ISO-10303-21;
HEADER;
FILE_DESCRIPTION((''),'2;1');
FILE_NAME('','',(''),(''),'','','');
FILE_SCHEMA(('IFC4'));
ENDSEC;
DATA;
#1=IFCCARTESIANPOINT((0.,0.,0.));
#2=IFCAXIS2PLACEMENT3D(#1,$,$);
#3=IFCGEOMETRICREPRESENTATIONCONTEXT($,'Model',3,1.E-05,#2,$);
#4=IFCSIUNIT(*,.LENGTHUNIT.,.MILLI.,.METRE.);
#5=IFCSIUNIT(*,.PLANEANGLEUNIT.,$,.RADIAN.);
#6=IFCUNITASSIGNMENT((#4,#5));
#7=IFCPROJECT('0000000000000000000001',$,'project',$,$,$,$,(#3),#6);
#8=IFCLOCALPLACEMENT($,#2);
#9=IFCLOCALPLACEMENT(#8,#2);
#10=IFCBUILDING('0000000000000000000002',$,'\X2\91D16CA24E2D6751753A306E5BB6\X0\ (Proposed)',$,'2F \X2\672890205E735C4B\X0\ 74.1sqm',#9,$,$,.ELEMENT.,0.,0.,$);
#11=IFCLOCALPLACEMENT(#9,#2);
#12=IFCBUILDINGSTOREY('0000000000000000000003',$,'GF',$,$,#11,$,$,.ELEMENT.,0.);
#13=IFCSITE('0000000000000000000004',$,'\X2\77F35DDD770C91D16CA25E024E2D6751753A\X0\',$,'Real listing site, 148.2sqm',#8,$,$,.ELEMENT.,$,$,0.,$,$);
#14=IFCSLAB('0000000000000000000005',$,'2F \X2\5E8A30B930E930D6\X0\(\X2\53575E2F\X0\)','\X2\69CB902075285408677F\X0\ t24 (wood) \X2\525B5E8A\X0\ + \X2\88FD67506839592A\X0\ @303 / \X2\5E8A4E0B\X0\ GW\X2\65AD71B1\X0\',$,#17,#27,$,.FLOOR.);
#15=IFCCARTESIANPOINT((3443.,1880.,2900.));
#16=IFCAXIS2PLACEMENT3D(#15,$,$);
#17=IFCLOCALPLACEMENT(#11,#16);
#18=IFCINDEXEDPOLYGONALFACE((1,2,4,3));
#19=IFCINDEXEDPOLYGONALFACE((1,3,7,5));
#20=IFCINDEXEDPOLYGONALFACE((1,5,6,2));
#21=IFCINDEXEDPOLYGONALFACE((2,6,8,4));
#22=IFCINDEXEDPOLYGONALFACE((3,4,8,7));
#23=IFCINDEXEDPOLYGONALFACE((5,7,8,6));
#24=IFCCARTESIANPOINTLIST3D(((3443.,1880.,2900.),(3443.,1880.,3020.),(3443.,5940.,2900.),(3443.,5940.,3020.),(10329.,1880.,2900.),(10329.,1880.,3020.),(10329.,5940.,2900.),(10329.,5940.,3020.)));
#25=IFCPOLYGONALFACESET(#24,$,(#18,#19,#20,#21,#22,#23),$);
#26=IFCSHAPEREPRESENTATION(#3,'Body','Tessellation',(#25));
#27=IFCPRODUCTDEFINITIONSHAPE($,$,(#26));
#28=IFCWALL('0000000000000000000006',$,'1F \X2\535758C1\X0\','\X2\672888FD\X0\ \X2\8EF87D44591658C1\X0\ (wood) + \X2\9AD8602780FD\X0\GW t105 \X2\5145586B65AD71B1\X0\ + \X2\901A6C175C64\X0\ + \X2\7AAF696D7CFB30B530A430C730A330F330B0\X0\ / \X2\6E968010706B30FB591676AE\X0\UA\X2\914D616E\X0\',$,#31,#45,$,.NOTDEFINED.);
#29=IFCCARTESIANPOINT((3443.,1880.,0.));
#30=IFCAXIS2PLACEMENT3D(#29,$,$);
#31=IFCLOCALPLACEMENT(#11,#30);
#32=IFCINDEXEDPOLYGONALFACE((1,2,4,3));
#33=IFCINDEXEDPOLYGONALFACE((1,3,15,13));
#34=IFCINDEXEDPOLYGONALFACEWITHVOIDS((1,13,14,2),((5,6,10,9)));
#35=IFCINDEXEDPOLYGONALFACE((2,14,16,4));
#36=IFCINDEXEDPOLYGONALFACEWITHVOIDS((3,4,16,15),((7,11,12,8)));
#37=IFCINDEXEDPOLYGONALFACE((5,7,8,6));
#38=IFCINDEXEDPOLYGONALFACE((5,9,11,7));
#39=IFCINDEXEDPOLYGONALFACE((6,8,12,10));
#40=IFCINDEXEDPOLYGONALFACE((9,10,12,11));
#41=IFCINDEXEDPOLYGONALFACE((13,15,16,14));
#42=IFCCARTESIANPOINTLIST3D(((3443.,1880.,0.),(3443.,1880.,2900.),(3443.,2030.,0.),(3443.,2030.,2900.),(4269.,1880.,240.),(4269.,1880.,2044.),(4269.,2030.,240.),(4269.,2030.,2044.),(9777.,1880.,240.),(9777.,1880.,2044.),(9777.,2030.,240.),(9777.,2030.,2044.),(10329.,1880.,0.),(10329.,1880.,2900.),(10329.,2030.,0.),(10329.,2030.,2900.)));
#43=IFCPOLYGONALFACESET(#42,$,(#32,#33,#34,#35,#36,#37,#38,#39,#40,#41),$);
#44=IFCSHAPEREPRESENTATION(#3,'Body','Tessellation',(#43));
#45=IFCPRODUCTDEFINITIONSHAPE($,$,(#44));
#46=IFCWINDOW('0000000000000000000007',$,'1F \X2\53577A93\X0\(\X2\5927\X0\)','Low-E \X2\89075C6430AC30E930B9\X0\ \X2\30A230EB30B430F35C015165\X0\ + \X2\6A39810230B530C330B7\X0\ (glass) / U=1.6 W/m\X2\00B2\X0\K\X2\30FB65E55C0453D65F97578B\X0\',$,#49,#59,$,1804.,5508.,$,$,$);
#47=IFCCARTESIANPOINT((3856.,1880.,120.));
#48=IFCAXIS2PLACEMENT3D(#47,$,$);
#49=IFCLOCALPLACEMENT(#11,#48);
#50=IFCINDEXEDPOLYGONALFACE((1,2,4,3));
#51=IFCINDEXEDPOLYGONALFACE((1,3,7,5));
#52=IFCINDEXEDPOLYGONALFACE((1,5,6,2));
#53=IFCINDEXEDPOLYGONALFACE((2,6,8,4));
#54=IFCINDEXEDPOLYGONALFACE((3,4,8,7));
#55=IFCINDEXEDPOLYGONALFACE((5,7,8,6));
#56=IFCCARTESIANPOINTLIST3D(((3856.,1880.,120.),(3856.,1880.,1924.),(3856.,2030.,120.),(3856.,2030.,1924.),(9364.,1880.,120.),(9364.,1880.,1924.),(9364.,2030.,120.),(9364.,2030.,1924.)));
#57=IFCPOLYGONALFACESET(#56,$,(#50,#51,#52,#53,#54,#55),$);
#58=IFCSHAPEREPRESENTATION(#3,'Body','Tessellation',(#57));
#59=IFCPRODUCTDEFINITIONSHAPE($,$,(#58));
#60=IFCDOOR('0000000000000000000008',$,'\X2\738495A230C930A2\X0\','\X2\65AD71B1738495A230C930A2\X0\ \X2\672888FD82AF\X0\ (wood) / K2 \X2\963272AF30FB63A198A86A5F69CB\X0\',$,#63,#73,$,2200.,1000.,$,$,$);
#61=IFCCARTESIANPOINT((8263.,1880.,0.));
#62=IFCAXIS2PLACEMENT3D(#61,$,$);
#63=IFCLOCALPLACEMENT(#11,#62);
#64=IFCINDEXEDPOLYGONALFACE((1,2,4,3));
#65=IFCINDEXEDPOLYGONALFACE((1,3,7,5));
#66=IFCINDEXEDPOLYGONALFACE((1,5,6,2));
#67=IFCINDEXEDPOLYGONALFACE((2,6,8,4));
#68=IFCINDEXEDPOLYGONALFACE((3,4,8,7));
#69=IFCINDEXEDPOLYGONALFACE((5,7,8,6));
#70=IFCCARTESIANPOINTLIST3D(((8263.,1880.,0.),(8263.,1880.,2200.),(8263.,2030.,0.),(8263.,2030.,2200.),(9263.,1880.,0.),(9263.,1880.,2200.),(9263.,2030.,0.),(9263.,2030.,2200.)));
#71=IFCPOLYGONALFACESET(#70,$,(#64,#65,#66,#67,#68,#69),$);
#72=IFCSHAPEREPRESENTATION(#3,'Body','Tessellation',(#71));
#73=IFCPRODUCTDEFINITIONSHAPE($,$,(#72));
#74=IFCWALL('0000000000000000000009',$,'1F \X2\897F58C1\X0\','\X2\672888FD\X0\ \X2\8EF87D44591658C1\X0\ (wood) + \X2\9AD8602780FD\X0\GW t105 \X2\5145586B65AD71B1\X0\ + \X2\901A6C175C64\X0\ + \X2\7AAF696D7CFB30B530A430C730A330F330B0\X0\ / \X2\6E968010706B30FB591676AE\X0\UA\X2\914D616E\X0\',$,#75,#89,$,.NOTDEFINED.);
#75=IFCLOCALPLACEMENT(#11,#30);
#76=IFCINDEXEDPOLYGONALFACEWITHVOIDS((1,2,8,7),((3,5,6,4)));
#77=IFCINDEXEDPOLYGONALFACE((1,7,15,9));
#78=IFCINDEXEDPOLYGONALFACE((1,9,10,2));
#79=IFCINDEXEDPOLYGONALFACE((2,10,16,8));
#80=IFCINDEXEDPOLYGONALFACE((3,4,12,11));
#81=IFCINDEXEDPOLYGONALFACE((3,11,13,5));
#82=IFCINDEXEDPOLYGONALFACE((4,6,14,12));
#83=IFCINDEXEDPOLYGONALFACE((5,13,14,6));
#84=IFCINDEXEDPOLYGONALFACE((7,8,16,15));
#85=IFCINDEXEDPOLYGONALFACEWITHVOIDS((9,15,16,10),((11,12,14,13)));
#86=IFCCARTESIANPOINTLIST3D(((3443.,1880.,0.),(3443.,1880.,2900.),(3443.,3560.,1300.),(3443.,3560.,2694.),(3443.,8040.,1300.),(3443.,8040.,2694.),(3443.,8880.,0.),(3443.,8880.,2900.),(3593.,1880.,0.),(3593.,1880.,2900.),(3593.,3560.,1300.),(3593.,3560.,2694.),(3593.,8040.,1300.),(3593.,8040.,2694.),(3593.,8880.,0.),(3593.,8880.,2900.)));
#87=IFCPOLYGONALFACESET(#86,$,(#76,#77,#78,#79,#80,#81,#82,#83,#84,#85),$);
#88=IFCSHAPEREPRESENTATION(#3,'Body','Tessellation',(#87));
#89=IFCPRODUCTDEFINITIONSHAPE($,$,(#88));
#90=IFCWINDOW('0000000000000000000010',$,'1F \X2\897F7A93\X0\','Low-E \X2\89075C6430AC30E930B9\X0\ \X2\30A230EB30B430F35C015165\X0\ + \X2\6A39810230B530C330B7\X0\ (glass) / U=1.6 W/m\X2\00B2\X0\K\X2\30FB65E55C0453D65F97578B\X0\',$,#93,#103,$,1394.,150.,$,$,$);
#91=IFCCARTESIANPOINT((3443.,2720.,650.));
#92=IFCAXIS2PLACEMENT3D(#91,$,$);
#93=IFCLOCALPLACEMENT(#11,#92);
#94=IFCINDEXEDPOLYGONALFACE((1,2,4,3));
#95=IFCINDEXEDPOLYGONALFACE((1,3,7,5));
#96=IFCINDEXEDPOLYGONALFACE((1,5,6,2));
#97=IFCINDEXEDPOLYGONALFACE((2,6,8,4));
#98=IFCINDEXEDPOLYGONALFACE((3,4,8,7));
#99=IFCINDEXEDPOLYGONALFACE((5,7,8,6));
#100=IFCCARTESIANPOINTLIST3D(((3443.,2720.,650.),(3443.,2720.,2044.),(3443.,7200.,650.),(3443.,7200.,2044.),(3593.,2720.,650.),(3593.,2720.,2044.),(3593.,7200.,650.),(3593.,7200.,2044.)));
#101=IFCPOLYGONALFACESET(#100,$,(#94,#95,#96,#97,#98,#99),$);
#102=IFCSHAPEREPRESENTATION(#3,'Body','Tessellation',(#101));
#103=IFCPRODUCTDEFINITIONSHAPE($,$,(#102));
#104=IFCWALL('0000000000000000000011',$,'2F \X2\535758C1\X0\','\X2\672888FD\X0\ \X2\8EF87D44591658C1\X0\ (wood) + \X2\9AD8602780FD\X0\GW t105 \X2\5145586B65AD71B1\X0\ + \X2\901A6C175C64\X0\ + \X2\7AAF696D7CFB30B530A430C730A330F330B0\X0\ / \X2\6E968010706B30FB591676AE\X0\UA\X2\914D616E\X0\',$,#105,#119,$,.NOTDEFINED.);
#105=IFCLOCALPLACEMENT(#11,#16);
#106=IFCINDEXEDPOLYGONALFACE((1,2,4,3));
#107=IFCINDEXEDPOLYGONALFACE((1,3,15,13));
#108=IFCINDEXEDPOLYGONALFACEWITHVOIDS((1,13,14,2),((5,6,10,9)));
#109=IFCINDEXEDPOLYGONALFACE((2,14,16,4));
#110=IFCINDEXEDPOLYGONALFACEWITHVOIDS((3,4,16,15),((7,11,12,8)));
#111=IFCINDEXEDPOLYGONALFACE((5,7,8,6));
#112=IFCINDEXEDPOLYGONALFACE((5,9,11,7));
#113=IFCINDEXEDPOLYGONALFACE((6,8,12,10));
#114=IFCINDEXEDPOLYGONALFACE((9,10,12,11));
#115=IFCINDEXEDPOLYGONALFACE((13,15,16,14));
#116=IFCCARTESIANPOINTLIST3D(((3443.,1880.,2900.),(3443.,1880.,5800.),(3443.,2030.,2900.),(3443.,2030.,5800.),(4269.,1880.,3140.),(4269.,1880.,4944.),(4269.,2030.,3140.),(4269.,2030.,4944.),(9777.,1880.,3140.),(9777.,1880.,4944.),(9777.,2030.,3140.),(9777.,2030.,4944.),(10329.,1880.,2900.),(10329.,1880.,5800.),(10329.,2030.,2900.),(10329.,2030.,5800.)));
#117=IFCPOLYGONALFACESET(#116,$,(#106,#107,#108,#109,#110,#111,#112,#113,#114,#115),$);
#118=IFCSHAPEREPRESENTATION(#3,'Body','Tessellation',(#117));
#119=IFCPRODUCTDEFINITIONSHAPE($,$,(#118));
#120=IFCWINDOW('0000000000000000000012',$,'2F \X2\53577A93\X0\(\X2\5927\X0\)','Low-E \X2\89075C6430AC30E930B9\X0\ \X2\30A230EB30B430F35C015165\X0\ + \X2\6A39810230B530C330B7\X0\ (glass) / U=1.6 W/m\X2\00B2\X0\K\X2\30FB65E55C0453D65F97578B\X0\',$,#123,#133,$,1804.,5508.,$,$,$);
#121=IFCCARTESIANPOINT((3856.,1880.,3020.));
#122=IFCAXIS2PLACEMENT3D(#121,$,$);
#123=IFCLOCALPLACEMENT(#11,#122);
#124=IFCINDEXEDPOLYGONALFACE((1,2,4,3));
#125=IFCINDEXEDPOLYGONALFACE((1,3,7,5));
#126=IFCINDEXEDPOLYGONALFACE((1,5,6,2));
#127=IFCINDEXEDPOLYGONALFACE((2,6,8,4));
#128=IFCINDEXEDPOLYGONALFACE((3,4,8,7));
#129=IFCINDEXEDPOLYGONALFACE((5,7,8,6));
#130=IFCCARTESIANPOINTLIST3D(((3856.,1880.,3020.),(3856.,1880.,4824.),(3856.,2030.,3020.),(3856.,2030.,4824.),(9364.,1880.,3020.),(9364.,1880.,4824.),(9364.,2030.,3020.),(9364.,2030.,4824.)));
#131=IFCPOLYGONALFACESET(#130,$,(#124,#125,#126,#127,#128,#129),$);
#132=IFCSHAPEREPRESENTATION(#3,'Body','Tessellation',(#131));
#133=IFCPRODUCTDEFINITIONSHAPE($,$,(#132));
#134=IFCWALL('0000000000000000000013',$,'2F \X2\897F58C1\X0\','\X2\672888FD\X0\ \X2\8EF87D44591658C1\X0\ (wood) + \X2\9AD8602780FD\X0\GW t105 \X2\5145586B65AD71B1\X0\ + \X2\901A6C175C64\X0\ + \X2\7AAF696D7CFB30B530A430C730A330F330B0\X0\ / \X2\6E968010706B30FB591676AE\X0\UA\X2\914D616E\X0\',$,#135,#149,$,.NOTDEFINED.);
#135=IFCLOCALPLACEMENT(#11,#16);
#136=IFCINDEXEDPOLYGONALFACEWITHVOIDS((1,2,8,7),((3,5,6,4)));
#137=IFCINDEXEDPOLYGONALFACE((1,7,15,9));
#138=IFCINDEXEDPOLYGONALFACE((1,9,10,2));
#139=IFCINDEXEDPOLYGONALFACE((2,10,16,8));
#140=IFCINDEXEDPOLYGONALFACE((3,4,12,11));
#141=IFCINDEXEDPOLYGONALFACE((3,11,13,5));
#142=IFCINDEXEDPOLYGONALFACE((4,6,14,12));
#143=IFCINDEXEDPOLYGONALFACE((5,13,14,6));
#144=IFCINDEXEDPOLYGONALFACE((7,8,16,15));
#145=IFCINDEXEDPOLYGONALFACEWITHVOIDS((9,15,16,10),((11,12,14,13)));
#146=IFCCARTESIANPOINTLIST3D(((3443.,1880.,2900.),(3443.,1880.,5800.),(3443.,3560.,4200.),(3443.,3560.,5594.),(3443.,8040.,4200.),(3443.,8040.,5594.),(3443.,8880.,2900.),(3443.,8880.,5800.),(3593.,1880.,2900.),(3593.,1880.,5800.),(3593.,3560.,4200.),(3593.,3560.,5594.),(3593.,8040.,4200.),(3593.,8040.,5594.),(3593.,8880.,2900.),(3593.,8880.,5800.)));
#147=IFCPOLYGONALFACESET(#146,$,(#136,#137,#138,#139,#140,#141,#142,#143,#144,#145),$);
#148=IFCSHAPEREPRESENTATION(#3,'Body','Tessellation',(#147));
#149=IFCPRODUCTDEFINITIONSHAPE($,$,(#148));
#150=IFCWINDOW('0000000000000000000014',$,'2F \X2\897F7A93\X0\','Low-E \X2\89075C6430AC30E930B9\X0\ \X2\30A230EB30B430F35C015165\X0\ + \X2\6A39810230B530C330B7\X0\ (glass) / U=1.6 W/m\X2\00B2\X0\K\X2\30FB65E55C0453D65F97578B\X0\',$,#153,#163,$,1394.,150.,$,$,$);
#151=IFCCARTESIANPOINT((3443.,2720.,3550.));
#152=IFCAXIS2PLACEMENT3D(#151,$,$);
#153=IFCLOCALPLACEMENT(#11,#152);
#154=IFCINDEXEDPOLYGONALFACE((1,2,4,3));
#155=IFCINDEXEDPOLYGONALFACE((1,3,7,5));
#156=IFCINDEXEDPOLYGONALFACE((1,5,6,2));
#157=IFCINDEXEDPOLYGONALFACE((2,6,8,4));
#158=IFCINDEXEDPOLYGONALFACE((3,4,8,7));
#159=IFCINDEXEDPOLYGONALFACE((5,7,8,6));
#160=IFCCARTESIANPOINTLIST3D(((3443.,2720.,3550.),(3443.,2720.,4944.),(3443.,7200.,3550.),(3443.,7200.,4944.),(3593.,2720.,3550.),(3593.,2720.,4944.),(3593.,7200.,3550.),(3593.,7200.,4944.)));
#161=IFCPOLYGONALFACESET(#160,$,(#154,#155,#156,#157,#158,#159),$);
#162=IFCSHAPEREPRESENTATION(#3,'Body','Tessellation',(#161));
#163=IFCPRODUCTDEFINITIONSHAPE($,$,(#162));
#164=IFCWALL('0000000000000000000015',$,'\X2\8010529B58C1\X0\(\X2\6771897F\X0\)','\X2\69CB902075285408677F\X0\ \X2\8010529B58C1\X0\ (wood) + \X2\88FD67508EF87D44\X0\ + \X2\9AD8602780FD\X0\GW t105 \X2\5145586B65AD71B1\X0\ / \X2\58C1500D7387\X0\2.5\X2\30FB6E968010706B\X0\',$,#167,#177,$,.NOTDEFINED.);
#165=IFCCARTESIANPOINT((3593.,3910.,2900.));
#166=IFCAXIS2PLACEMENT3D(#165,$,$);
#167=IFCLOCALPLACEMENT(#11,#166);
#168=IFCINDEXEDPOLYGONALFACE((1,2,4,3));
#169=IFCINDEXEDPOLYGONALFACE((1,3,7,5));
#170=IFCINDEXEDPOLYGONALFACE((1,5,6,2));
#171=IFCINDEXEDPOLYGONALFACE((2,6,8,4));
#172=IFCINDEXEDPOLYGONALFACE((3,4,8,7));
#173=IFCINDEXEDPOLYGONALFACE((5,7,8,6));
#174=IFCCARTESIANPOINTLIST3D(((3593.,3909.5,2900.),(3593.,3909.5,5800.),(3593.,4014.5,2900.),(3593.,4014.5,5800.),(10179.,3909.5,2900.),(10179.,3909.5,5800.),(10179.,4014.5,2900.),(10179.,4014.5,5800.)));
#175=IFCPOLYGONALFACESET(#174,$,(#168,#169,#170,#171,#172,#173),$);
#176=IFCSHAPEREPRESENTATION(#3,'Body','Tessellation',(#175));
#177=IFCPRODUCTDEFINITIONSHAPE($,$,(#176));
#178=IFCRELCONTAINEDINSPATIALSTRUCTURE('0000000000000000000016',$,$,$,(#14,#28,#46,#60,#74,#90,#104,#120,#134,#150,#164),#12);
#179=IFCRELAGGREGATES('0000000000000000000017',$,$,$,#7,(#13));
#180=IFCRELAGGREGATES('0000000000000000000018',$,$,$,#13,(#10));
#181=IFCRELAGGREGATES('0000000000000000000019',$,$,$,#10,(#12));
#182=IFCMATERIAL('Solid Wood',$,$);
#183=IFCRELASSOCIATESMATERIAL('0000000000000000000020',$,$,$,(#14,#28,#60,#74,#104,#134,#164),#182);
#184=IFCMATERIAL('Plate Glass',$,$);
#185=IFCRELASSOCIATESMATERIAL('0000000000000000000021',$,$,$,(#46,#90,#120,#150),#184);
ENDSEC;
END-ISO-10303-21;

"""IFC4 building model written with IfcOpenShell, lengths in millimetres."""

from ifc_helpers import new_model, si_unit, frame, frame_2d, origin, place, context, project, spatial, rectangle, extrude, material, element, fill, save


model = new_model("IFC4")

# Units and contexts
model_context = context("Model", 3, precision=1e-05, world=origin())
ifc_project = project(units=[si_unit("LENGTHUNIT", "METRE", prefix="MILLI"), si_unit("PLANEANGLEUNIT", "RADIAN")], contexts=[model_context])

# Site, building, storey
site_placement = place(None, origin())
site = spatial("IfcSite", under=ifc_project, at=site_placement, Name="石川県金沢市中村町", ObjectType="Real listing site, 148.2sqm", CompositionType="ELEMENT", RefElevation=0.0)
building_placement = place(site_placement, origin())
building = spatial("IfcBuilding", under=site, at=building_placement, Name="金沢中村町の家 (Proposed)", ObjectType="2F 木造平屋 74.1sqm", CompositionType="ELEMENT", ElevationOfRefHeight=0.0, ElevationOfTerrain=0.0)
storey_placement = place(building_placement, origin())
storey = spatial("IfcBuildingStorey", under=building, at=storey_placement, Name="GF", CompositionType="ELEMENT", Elevation=0.0)

# Slab
ifc_material_1 = material(Name="Solid Wood")
slab_1_placement = place(storey_placement, frame((3443.0, 1880.0, 2900.0)))
element("IfcSlab", 1, at=slab_1_placement, inside=storey, material=ifc_material_1, Name="2F 床スラブ(南帯)", Description="構造用合板 t24 (wood) 剛床 + 製材根太 @303 / 床下 GW断熱", PredefinedType="FLOOR", context=model_context, shape_type="SweptSolid", body=[
    extrude(rectangle(XDim=6886.0, YDim=4060.0, at=frame_2d((3443.0, 2030.0))), frame((3443.0, 1880.0, 2900.0)), (0.0, 0.0, 1.0), 120.0),
])

# Wall, openings, window, door
wall_1_placement = place(storey_placement, frame((3443.0, 1880.0, 0.0)))
wall_1 = element("IfcWall", 2, at=wall_1_placement, inside=storey, material=ifc_material_1, Name="1F 南壁", Description="木製 軸組外壁 (wood) + 高性能GW t105 充填断熱 + 通気層 + 窯業系サイディング / 準耐火・外皮UA配慮", PredefinedType="NOTDEFINED", context=model_context, shape_type="SweptSolid", body=[
    extrude(rectangle(XDim=6886.0, YDim=150.0, at=frame_2d((3443.0, 75.0))), frame((3443.0, 1880.0, 0.0)), (0.0, 0.0, 1.0), 2900.0),
])
opening_1_placement = place(storey_placement, frame((3856.0, 1880.0, 120.0)))
opening_1 = element("IfcOpeningElement", 3, at=opening_1_placement, cuts=wall_1, PredefinedType="NOTDEFINED", context=model_context, shape_type="SweptSolid", body=[
    extrude(rectangle(XDim=5508.0, YDim=150.0, at=frame_2d((2754.0, 75.0))), frame((3856.0, 1880.0, 120.0)), (0.0, 0.0, 1.0), 1804.0),
])
opening_2_placement = place(storey_placement, frame((8263.0, 1880.0, 0.0)))
opening_2 = element("IfcOpeningElement", 4, at=opening_2_placement, cuts=wall_1, PredefinedType="NOTDEFINED", context=model_context, shape_type="SweptSolid", body=[
    extrude(rectangle(XDim=1000.0, YDim=150.0, at=frame_2d((500.0, 75.0))), frame((8263.0, 1880.0, 0.0)), (0.0, 0.0, 1.0), 2200.0),
])
ifc_material_2 = material(Name="Plate Glass")
window_1_placement = place(storey_placement, frame((3856.0, 1880.0, 120.0)))
window_1 = element("IfcWindow", 5, at=window_1_placement, inside=storey, material=ifc_material_2, Name="1F 南窓(大)", Description="Low-E 複層ガラス アルゴン封入 + 樹脂サッシ (glass) / U=1.6 W/m²K・日射取得型", OverallHeight=1804.0, OverallWidth=5508.0, context=model_context, shape_type="SweptSolid", body=[
    extrude(rectangle(XDim=5508.0, YDim=150.0, at=frame_2d((2754.0, 75.0))), frame((3856.0, 1880.0, 120.0)), (0.0, 0.0, 1.0), 1804.0),
])
fill(opening_1, window_1)
door_placement = place(storey_placement, frame((8263.0, 1880.0, 0.0)))
door = element("IfcDoor", 6, at=door_placement, inside=storey, material=ifc_material_1, Name="玄関ドア", Description="断熱玄関ドア 木製芯 (wood) / K2 防犯・採風機構", OverallHeight=2200.0, OverallWidth=1000.0, context=model_context, shape_type="SweptSolid", body=[
    extrude(rectangle(XDim=1000.0, YDim=150.0, at=frame_2d((500.0, 75.0))), frame((8263.0, 1880.0, 0.0)), (0.0, 0.0, 1.0), 2200.0),
])
fill(opening_2, door)

# Wall, opening, window
wall_2_placement = place(storey_placement, frame((3443.0, 1880.0, 0.0)))
wall_2 = element("IfcWall", 7, at=wall_2_placement, inside=storey, material=ifc_material_1, Name="1F 西壁", Description="木製 軸組外壁 (wood) + 高性能GW t105 充填断熱 + 通気層 + 窯業系サイディング / 準耐火・外皮UA配慮", PredefinedType="NOTDEFINED", context=model_context, shape_type="SweptSolid", body=[
    extrude(rectangle(XDim=150.0, YDim=7000.0, at=frame_2d((75.0, 3500.0))), frame((3443.0, 1880.0, 0.0)), (0.0, 0.0, 1.0), 2900.0),
])
opening_3_placement = place(storey_placement, frame((3443.0, 2720.0, 650.0)))
opening_3 = element("IfcOpeningElement", 8, at=opening_3_placement, cuts=wall_2, PredefinedType="NOTDEFINED", context=model_context, shape_type="SweptSolid", body=[
    extrude(rectangle(XDim=150.0, YDim=4480.0, at=frame_2d((75.0, 2240.0))), frame((3443.0, 2720.0, 650.0)), (0.0, 0.0, 1.0), 1394.0),
])
window_2_placement = place(storey_placement, frame((3443.0, 2720.0, 650.0)))
window_2 = element("IfcWindow", 9, at=window_2_placement, inside=storey, material=ifc_material_2, Name="1F 西窓", Description="Low-E 複層ガラス アルゴン封入 + 樹脂サッシ (glass) / U=1.6 W/m²K・日射取得型", OverallHeight=1394.0, OverallWidth=150.0, context=model_context, shape_type="SweptSolid", body=[
    extrude(rectangle(XDim=150.0, YDim=4480.0, at=frame_2d((75.0, 2240.0))), frame((3443.0, 2720.0, 650.0)), (0.0, 0.0, 1.0), 1394.0),
])
fill(opening_3, window_2)

# Walls, openings, windows
wall_3_placement = place(storey_placement, frame((3443.0, 1880.0, 2900.0)))
wall_3 = element("IfcWall", 10, at=wall_3_placement, inside=storey, material=ifc_material_1, Name="2F 南壁", Description="木製 軸組外壁 (wood) + 高性能GW t105 充填断熱 + 通気層 + 窯業系サイディング / 準耐火・外皮UA配慮", PredefinedType="NOTDEFINED", context=model_context, shape_type="SweptSolid", body=[
    extrude(rectangle(XDim=6886.0, YDim=150.0, at=frame_2d((3443.0, 75.0))), frame((3443.0, 1880.0, 2900.0)), (0.0, 0.0, 1.0), 2900.0),
])
opening_4_placement = place(storey_placement, frame((3856.0, 1880.0, 3020.0)))
opening_4 = element("IfcOpeningElement", 11, at=opening_4_placement, cuts=wall_3, PredefinedType="NOTDEFINED", context=model_context, shape_type="SweptSolid", body=[
    extrude(rectangle(XDim=5508.0, YDim=150.0, at=frame_2d((2754.0, 75.0))), frame((3856.0, 1880.0, 3020.0)), (0.0, 0.0, 1.0), 1804.0),
])
window_3_placement = place(storey_placement, frame((3856.0, 1880.0, 3020.0)))
window_3 = element("IfcWindow", 12, at=window_3_placement, inside=storey, material=ifc_material_2, Name="2F 南窓(大)", Description="Low-E 複層ガラス アルゴン封入 + 樹脂サッシ (glass) / U=1.6 W/m²K・日射取得型", OverallHeight=1804.0, OverallWidth=5508.0, context=model_context, shape_type="SweptSolid", body=[
    extrude(rectangle(XDim=5508.0, YDim=150.0, at=frame_2d((2754.0, 75.0))), frame((3856.0, 1880.0, 3020.0)), (0.0, 0.0, 1.0), 1804.0),
])
fill(opening_4, window_3)
wall_4_placement = place(storey_placement, frame((3443.0, 1880.0, 2900.0)))
wall_4 = element("IfcWall", 13, at=wall_4_placement, inside=storey, material=ifc_material_1, Name="2F 西壁", Description="木製 軸組外壁 (wood) + 高性能GW t105 充填断熱 + 通気層 + 窯業系サイディング / 準耐火・外皮UA配慮", PredefinedType="NOTDEFINED", context=model_context, shape_type="SweptSolid", body=[
    extrude(rectangle(XDim=150.0, YDim=7000.0, at=frame_2d((75.0, 3500.0))), frame((3443.0, 1880.0, 2900.0)), (0.0, 0.0, 1.0), 2900.0),
])
opening_5_placement = place(storey_placement, frame((3443.0, 2720.0, 3550.0)))
opening_5 = element("IfcOpeningElement", 14, at=opening_5_placement, cuts=wall_4, PredefinedType="NOTDEFINED", context=model_context, shape_type="SweptSolid", body=[
    extrude(rectangle(XDim=150.0, YDim=4480.0, at=frame_2d((75.0, 2240.0))), frame((3443.0, 2720.0, 3550.0)), (0.0, 0.0, 1.0), 1394.0),
])
window_4_placement = place(storey_placement, frame((3443.0, 2720.0, 3550.0)))
window_4 = element("IfcWindow", 15, at=window_4_placement, inside=storey, material=ifc_material_2, Name="2F 西窓", Description="Low-E 複層ガラス アルゴン封入 + 樹脂サッシ (glass) / U=1.6 W/m²K・日射取得型", OverallHeight=1394.0, OverallWidth=150.0, context=model_context, shape_type="SweptSolid", body=[
    extrude(rectangle(XDim=150.0, YDim=4480.0, at=frame_2d((75.0, 2240.0))), frame((3443.0, 2720.0, 3550.0)), (0.0, 0.0, 1.0), 1394.0),
])
fill(opening_5, window_4)

# Wall
wall_5_placement = place(storey_placement, frame((3593.0, 3910.0, 2900.0)))
element("IfcWall", 16, at=wall_5_placement, inside=storey, material=ifc_material_1, Name="耐力壁(東西)", Description="構造用合板 耐力壁 (wood) + 製材軸組 + 高性能GW t105 充填断熱 / 壁倍率2.5・準耐火", PredefinedType="NOTDEFINED", context=model_context, shape_type="SweptSolid", body=[
    extrude(rectangle(XDim=6586.0, YDim=105.0, at=frame_2d((3293.0, 52.0))), frame((3593.0, 3910.0, 2900.0)), (0.0, 0.0, 1.0), 2900.0),
])

save(model, "model.ifc")
